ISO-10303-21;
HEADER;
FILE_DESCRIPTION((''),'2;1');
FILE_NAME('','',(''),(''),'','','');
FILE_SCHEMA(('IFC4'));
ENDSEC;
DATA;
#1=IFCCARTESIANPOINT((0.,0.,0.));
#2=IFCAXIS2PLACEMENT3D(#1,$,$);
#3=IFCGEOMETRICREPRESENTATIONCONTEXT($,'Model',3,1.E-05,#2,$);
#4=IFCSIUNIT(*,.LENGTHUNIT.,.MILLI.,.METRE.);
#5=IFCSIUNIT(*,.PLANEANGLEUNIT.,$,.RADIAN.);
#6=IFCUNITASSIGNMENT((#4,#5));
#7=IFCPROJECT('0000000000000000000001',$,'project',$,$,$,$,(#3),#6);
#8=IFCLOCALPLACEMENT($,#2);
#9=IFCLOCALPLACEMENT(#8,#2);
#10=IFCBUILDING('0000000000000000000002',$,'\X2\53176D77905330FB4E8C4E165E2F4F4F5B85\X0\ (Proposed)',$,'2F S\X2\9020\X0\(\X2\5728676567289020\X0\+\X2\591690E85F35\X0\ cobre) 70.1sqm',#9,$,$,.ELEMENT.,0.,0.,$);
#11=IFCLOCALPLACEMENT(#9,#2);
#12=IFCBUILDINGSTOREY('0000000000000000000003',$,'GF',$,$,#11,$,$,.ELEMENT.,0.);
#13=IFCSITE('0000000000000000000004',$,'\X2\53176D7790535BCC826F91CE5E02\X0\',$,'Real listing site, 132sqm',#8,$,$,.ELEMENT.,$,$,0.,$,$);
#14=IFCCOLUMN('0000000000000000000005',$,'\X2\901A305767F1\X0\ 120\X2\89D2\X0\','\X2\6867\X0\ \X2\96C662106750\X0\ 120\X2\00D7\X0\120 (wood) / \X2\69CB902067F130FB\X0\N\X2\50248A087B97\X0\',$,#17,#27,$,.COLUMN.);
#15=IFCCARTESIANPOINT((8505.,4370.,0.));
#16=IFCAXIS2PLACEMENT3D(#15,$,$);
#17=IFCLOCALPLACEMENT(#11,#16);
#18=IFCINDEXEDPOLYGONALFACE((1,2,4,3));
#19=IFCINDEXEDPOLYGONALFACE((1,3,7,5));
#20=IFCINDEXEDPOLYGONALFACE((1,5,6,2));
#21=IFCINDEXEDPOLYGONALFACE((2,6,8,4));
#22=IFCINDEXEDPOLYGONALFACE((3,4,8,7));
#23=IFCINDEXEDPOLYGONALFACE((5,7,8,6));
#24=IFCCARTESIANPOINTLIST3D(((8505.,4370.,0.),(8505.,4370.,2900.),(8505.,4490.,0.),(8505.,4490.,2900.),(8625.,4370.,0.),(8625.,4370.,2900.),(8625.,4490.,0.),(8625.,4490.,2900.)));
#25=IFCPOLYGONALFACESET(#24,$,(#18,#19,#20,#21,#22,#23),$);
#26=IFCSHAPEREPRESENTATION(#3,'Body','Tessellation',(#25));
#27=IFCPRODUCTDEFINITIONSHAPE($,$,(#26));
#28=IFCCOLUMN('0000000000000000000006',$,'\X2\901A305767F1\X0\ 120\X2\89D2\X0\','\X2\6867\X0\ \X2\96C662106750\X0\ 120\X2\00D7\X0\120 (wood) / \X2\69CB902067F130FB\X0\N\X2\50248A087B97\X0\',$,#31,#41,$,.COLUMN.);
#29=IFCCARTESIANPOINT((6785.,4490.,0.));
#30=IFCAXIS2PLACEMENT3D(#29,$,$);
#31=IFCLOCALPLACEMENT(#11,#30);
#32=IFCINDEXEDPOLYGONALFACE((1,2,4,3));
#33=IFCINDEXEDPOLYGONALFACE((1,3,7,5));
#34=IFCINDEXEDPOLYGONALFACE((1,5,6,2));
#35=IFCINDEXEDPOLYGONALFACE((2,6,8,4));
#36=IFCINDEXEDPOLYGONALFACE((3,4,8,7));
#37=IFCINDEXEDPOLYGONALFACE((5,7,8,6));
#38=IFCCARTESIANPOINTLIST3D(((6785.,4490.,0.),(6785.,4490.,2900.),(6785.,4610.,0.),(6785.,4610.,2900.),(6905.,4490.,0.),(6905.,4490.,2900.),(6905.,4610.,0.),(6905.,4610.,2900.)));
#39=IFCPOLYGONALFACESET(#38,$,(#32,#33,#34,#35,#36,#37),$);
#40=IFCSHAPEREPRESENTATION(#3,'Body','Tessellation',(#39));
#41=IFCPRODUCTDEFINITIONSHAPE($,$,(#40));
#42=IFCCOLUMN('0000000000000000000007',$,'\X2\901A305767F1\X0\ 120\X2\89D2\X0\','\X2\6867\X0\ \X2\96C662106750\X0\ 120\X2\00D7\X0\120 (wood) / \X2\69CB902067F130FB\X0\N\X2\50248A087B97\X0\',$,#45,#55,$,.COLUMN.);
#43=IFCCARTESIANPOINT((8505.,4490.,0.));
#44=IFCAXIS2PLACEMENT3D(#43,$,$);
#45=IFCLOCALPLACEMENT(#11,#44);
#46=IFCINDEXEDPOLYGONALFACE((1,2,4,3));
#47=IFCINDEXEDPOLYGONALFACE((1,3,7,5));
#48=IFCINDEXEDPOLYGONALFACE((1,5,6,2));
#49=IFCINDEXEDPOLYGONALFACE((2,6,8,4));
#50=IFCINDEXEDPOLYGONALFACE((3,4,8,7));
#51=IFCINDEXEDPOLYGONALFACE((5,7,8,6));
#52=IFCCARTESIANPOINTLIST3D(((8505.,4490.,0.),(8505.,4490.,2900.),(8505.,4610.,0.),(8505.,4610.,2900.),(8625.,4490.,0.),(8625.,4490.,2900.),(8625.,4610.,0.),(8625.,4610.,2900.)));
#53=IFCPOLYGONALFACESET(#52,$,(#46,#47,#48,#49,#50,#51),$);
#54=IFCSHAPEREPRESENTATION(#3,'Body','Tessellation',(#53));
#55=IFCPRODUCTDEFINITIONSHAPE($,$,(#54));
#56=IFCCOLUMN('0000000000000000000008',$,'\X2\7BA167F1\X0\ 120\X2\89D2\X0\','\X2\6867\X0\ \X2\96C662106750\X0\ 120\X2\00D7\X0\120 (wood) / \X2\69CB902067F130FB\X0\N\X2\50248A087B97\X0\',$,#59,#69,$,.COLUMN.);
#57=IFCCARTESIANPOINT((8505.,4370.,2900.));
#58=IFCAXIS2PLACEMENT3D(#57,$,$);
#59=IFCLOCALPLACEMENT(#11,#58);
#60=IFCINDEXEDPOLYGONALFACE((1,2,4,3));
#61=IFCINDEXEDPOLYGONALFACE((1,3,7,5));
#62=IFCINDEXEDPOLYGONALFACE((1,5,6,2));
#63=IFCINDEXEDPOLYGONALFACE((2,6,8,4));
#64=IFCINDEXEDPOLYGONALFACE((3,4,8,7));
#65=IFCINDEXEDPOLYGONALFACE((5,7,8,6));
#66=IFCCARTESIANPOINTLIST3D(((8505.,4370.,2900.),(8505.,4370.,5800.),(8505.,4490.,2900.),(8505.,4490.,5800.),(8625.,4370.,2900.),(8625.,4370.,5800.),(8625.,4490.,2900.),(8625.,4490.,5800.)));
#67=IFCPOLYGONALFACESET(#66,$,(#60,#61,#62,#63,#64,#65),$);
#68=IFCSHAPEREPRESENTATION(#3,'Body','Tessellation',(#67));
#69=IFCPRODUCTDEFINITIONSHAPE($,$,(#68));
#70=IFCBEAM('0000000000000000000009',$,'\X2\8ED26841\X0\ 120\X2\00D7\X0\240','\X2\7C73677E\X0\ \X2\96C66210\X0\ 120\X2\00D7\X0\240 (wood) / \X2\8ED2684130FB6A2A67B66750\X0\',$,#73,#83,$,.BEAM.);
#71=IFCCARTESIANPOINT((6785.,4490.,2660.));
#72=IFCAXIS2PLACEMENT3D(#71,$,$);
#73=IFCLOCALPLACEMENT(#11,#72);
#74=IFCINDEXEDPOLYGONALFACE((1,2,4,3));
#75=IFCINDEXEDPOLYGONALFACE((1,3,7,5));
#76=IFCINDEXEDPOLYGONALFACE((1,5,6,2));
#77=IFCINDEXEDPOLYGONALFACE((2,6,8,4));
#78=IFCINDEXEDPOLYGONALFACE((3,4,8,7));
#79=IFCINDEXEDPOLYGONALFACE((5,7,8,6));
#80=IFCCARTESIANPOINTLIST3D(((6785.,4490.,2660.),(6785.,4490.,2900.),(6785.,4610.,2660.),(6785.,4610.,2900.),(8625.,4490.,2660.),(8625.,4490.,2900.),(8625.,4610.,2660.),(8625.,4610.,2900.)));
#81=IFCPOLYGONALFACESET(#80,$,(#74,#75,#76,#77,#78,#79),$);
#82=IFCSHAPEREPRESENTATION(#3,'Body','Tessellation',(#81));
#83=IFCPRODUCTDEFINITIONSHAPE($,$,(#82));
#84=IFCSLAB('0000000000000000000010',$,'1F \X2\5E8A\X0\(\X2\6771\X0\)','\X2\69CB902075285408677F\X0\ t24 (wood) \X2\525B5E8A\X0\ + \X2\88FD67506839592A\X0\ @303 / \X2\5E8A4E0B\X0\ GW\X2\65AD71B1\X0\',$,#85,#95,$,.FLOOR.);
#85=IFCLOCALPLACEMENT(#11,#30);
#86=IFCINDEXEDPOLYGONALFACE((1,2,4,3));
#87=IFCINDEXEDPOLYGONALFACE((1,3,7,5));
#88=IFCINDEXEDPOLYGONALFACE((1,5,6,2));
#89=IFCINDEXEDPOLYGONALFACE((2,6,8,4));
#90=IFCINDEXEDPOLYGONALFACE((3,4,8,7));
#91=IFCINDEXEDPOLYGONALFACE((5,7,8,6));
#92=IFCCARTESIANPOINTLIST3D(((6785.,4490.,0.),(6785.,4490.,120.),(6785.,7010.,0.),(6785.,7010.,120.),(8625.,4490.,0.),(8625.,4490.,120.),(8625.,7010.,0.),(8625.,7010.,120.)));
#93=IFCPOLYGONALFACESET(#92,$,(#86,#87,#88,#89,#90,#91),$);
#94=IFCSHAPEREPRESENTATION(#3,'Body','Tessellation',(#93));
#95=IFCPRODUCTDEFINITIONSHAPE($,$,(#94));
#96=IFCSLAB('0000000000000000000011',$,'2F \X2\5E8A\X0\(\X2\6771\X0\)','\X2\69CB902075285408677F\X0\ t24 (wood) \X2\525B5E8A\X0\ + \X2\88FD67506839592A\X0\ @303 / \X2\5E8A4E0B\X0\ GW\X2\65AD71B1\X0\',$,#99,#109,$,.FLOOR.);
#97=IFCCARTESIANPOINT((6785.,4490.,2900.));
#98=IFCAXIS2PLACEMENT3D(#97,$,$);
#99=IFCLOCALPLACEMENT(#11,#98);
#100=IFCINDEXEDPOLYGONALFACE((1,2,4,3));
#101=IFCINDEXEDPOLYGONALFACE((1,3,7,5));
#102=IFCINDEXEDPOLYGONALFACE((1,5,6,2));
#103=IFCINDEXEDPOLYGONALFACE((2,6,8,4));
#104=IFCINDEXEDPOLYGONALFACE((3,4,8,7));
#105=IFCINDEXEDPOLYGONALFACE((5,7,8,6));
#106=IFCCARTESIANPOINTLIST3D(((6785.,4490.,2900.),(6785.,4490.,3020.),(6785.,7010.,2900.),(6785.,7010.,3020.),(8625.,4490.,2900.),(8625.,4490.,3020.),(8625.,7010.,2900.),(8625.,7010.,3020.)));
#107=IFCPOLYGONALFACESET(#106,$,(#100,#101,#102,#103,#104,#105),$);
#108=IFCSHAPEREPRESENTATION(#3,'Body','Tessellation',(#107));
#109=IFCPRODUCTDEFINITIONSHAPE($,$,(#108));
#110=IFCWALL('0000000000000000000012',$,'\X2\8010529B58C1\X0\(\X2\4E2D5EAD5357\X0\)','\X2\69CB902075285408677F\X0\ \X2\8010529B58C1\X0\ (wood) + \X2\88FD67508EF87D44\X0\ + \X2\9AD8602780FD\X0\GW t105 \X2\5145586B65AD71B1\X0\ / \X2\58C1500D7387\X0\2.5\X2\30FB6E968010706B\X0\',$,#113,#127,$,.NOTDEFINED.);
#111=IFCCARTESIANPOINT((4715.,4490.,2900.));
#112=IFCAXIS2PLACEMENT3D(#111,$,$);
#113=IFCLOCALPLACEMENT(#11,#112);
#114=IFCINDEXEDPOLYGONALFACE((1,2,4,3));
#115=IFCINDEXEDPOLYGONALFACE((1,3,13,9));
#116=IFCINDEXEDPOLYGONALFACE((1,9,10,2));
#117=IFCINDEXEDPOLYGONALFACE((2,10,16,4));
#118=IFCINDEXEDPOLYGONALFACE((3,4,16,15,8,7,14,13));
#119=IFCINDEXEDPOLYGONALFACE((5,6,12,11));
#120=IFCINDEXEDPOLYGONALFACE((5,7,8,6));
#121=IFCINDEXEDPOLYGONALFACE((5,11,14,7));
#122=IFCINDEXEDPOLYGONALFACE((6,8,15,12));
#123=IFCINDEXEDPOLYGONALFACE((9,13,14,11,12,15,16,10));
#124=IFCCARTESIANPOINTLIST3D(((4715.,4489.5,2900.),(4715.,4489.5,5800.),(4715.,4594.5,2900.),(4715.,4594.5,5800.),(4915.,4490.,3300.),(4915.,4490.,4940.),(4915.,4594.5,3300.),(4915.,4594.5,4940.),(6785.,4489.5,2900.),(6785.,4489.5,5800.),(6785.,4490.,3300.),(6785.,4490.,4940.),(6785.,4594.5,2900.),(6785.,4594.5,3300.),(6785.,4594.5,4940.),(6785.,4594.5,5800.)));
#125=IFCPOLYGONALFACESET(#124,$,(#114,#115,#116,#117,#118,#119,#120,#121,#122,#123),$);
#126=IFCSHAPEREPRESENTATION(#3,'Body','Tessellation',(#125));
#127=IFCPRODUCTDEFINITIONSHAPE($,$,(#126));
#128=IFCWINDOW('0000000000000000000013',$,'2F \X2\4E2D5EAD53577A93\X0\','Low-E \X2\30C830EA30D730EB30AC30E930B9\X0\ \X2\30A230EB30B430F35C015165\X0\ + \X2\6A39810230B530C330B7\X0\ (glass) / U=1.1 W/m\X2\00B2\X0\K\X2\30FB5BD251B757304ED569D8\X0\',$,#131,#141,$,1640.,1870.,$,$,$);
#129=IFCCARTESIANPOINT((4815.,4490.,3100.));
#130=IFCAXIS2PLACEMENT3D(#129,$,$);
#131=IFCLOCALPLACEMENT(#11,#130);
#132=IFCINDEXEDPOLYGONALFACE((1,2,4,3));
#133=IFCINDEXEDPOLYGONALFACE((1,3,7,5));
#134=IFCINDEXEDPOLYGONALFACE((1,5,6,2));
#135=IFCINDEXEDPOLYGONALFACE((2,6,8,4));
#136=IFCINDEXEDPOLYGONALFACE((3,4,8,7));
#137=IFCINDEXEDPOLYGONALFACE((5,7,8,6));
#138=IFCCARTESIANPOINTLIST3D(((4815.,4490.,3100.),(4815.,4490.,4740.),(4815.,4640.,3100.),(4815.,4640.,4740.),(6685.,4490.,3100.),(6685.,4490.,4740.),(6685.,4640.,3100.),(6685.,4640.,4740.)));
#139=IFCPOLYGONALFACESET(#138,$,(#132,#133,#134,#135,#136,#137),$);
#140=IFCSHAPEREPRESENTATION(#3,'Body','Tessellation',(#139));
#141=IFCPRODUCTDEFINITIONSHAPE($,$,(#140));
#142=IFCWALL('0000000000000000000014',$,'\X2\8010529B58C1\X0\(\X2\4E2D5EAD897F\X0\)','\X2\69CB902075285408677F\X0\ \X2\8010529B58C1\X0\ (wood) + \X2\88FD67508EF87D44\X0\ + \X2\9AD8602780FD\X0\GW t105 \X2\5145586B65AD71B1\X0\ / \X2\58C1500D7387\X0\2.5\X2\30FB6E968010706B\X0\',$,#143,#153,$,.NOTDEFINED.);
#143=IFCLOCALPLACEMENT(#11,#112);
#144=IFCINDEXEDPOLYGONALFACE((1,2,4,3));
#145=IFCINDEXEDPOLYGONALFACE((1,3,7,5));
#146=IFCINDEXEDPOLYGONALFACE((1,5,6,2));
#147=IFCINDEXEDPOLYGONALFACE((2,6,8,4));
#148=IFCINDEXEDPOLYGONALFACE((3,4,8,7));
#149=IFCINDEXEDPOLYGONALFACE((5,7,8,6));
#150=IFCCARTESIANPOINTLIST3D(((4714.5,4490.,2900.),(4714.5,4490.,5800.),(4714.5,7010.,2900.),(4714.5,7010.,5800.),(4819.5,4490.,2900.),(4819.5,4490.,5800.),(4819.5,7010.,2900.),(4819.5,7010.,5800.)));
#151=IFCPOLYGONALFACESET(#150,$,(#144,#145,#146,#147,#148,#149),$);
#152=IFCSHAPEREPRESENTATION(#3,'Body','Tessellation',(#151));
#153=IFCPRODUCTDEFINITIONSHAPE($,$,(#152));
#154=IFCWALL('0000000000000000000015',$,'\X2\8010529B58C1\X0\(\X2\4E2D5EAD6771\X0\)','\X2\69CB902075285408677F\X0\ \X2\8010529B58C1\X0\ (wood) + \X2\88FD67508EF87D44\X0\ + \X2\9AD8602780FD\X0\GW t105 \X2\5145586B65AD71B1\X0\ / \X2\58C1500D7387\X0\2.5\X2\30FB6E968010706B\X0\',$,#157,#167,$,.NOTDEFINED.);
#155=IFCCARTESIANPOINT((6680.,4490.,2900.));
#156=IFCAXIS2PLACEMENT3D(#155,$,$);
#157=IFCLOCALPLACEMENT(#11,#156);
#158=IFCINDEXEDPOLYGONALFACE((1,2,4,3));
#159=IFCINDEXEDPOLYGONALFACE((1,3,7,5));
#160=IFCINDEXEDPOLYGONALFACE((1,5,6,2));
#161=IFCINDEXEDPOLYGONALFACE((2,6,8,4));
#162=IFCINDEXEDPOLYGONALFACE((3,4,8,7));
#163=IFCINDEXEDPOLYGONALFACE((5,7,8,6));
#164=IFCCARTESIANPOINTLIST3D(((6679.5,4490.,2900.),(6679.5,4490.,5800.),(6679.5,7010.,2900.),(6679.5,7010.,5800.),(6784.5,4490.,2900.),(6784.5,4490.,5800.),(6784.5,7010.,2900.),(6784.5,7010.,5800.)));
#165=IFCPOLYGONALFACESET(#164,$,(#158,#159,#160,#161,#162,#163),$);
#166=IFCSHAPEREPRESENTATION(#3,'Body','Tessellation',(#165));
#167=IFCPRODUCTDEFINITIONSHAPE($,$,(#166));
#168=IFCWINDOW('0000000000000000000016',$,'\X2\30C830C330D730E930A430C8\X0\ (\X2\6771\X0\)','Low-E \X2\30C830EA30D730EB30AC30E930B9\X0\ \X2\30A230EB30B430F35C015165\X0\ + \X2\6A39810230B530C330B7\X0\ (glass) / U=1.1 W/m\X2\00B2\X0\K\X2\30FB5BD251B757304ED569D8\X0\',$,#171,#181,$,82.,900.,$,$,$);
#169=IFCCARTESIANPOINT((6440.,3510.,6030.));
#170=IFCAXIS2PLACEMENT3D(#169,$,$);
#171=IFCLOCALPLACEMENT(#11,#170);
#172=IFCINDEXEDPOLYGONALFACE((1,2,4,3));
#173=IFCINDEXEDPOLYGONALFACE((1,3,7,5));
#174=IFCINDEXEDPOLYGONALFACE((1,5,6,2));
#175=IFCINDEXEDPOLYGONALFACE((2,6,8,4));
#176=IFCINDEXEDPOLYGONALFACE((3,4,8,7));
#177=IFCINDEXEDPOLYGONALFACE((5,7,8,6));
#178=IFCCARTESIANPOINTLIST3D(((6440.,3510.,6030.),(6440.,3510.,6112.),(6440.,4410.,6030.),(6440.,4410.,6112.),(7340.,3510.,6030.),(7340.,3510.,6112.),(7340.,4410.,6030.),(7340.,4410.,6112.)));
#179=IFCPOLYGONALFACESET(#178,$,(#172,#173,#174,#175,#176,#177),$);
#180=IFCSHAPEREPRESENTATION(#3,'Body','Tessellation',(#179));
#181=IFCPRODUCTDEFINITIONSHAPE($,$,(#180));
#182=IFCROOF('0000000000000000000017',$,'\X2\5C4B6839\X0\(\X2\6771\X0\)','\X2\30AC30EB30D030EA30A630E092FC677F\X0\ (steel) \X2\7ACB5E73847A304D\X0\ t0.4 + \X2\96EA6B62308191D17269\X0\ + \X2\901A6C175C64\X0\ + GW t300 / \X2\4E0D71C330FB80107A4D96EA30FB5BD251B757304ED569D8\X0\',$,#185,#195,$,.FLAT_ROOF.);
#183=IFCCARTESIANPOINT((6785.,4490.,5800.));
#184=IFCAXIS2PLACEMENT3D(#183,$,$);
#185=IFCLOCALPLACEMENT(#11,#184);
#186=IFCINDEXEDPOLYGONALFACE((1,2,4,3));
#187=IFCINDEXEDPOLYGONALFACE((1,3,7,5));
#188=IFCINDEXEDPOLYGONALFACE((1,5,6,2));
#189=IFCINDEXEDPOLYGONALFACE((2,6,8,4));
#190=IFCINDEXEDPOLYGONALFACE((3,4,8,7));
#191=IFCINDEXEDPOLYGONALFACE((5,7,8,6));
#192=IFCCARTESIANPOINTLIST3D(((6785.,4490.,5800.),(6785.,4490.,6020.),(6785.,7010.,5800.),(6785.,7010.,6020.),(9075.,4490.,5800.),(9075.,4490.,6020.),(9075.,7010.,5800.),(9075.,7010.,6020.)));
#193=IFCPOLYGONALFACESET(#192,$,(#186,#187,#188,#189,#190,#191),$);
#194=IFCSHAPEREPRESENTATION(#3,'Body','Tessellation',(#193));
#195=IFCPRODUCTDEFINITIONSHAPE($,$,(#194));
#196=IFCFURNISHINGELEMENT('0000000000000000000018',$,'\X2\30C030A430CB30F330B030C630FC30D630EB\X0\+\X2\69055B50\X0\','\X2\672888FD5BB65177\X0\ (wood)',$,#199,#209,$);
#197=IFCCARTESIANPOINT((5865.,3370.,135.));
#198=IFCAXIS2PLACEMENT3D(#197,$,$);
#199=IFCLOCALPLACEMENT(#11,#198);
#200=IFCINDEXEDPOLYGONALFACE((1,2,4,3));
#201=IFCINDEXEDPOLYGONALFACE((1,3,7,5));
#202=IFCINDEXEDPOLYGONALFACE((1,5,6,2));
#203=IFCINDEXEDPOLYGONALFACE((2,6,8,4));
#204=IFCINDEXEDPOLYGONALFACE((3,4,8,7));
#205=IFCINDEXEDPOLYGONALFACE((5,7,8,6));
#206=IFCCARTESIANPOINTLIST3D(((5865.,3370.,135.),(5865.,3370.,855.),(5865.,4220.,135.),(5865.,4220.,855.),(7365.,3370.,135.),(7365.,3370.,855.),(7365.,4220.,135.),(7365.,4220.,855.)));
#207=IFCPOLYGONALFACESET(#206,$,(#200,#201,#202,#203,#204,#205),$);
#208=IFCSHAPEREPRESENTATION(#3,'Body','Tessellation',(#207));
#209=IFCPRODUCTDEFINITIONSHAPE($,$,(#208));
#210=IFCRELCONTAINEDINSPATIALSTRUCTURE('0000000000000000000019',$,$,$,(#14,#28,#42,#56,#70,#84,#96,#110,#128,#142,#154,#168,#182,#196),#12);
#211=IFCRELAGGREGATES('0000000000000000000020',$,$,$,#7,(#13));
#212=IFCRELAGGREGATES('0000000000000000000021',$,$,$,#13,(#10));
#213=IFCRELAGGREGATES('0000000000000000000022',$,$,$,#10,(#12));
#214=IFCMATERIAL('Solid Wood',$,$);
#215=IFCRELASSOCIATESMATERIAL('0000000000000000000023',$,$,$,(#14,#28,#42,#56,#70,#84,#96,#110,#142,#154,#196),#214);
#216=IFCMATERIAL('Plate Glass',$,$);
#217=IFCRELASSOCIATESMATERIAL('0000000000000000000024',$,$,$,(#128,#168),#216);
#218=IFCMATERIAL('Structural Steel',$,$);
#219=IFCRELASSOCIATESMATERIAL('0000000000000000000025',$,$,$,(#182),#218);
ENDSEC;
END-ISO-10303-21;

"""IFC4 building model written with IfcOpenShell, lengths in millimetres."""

from ifc_helpers import new_model, si_unit, frame, frame_2d, origin, place, context, project, spatial, rectangle, extrude, material, element, fill, save


model = new_model("IFC4")

# Units and contexts
model_context = context("Model", 3, precision=1e-05, world=origin())
ifc_project = project(units=[si_unit("LENGTHUNIT", "METRE", prefix="MILLI"), si_unit("PLANEANGLEUNIT", "RADIAN")], contexts=[model_context])

# Site, building, storey
site_placement = place(None, origin())
site = spatial("IfcSite", under=ifc_project, at=site_placement, Name="北海道富良野市", ObjectType="Real listing site, 132sqm", CompositionType="ELEMENT", RefElevation=0.0)
building_placement = place(site_placement, origin())
building = spatial("IfcBuilding", under=site, at=building_placement, Name="北海道・二世帯住宅 (Proposed)", ObjectType="2F S造(在来木造+外部張 cobre) 70.1sqm", CompositionType="ELEMENT", ElevationOfRefHeight=0.0, ElevationOfTerrain=0.0)
storey_placement = place(building_placement, origin())
storey = spatial("IfcBuildingStorey", under=building, at=storey_placement, Name="GF", CompositionType="ELEMENT", Elevation=0.0)

# Columns
ifc_material_1 = material(Name="Solid Wood")
column_1_placement = place(storey_placement, frame((8505.0, 4370.0, 0.0)))
element("IfcColumn", 1, at=column_1_placement, inside=storey, material=ifc_material_1, Name="通し柱 120角", Description="桧 集成材 120×120 (wood) / 構造柱・N値計算", PredefinedType="COLUMN", context=model_context, shape_type="SweptSolid", body=[
    extrude(rectangle(XDim=120.0, YDim=120.0, at=frame_2d((60.0, 60.0))), frame((8505.0, 4370.0, 0.0)), (0.0, 0.0, 1.0), 2900.0),
])
column_2_placement = place(storey_placement, frame((6785.0, 4490.0, 0.0)))
element("IfcColumn", 2, at=column_2_placement, inside=storey, material=ifc_material_1, Name="通し柱 120角", Description="桧 集成材 120×120 (wood) / 構造柱・N値計算", PredefinedType="COLUMN", context=model_context, shape_type="SweptSolid", body=[
    extrude(rectangle(XDim=120.0, YDim=120.0, at=frame_2d((60.0, 60.0))), frame((6785.0, 4490.0, 0.0)), (0.0, 0.0, 1.0), 2900.0),
])
column_3_placement = place(storey_placement, frame((8505.0, 4490.0, 0.0)))
element("IfcColumn", 3, at=column_3_placement, inside=storey, material=ifc_material_1, Name="通し柱 120角", Description="桧 集成材 120×120 (wood) / 構造柱・N値計算", PredefinedType="COLUMN", context=model_context, shape_type="SweptSolid", body=[
    extrude(rectangle(XDim=120.0, YDim=120.0, at=frame_2d((60.0, 60.0))), frame((8505.0, 4490.0, 0.0)), (0.0, 0.0, 1.0), 2900.0),
])
column_4_placement = place(storey_placement, frame((8505.0, 4370.0, 2900.0)))
element("IfcColumn", 4, at=column_4_placement, inside=storey, material=ifc_material_1, Name="管柱 120角", Description="桧 集成材 120×120 (wood) / 構造柱・N値計算", PredefinedType="COLUMN", context=model_context, shape_type="SweptSolid", body=[
    extrude(rectangle(XDim=120.0, YDim=120.0, at=frame_2d((60.0, 60.0))), frame((8505.0, 4370.0, 2900.0)), (0.0, 0.0, 1.0), 2900.0),
])

# Beam
beam_1_placement = place(storey_placement, frame((6785.0, 4490.0, 2660.0)))
element("IfcBeam", 5, at=beam_1_placement, inside=storey, material=ifc_material_1, Name="軒桁 120×240", Description="米松 集成 120×240 (wood) / 軒桁・横架材", PredefinedType="BEAM", context=model_context, shape_type="SweptSolid", body=[
    extrude(rectangle(XDim=1840.0, YDim=120.0, at=frame_2d((920.0, 60.0))), frame((6785.0, 4490.0, 2660.0)), (0.0, 0.0, 1.0), 240.0),
])

# Slabs
slab_1_placement = place(storey_placement, frame((6785.0, 4490.0, 0.0)))
element("IfcSlab", 6, at=slab_1_placement, inside=storey, material=ifc_material_1, Name="1F 床(東)", Description="構造用合板 t24 (wood) 剛床 + 製材根太 @303 / 床下 GW断熱", PredefinedType="FLOOR", context=model_context, shape_type="SweptSolid", body=[
    extrude(rectangle(XDim=1840.0, YDim=2520.0, at=frame_2d((920.0, 1260.0))), frame((6785.0, 4490.0, 0.0)), (0.0, 0.0, 1.0), 120.0),
])
slab_2_placement = place(storey_placement, frame((6785.0, 4490.0, 2900.0)))
element("IfcSlab", 7, at=slab_2_placement, inside=storey, material=ifc_material_1, Name="2F 床(東)", Description="構造用合板 t24 (wood) 剛床 + 製材根太 @303 / 床下 GW断熱", PredefinedType="FLOOR", context=model_context, shape_type="SweptSolid", body=[
    extrude(rectangle(XDim=1840.0, YDim=2520.0, at=frame_2d((920.0, 1260.0))), frame((6785.0, 4490.0, 2900.0)), (0.0, 0.0, 1.0), 120.0),
])

# Wall, opening, window
wall_1_placement = place(storey_placement, frame((4715.0, 4490.0, 2900.0)))
wall_1 = element("IfcWall", 8, at=wall_1_placement, inside=storey, material=ifc_material_1, Name="耐力壁(中庭南)", Description="構造用合板 耐力壁 (wood) + 製材軸組 + 高性能GW t105 充填断熱 / 壁倍率2.5・準耐火", PredefinedType="NOTDEFINED", context=model_context, shape_type="SweptSolid", body=[
    extrude(rectangle(XDim=2070.0, YDim=105.0, at=frame_2d((1035.0, 52.0))), frame((4715.0, 4490.0, 2900.0)), (0.0, 0.0, 1.0), 2900.0),
])
opening_placement = place(storey_placement, frame((4815.0, 4490.0, 3100.0)))
opening = element("IfcOpeningElement", 9, at=opening_placement, cuts=wall_1, PredefinedType="NOTDEFINED", context=model_context, shape_type="SweptSolid", body=[
    extrude(rectangle(XDim=1870.0, YDim=150.0, at=frame_2d((935.0, 75.0))), frame((4815.0, 4490.0, 3100.0)), (0.0, 0.0, 1.0), 1640.0),
])
ifc_material_2 = material(Name="Plate Glass")
window_1_placement = place(storey_placement, frame((4815.0, 4490.0, 3100.0)))
window_1 = element("IfcWindow", 10, at=window_1_placement, inside=storey, material=ifc_material_2, Name="2F 中庭南窓", Description="Low-E トリプルガラス アルゴン封入 + 樹脂サッシ (glass) / U=1.1 W/m²K・寒冷地仕様", OverallHeight=1640.0, OverallWidth=1870.0, context=model_context, shape_type="SweptSolid", body=[
    extrude(rectangle(XDim=1870.0, YDim=150.0, at=frame_2d((935.0, 75.0))), frame((4815.0, 4490.0, 3100.0)), (0.0, 0.0, 1.0), 1640.0),
])
fill(opening, window_1)

# Walls
wall_2_placement = place(storey_placement, frame((4715.0, 4490.0, 2900.0)))
element("IfcWall", 11, at=wall_2_placement, inside=storey, material=ifc_material_1, Name="耐力壁(中庭西)", Description="構造用合板 耐力壁 (wood) + 製材軸組 + 高性能GW t105 充填断熱 / 壁倍率2.5・準耐火", PredefinedType="NOTDEFINED", context=model_context, shape_type="SweptSolid", body=[
    extrude(rectangle(XDim=105.0, YDim=2520.0, at=frame_2d((52.0, 1260.0))), frame((4715.0, 4490.0, 2900.0)), (0.0, 0.0, 1.0), 2900.0),
])
wall_3_placement = place(storey_placement, frame((6680.0, 4490.0, 2900.0)))
element("IfcWall", 12, at=wall_3_placement, inside=storey, material=ifc_material_1, Name="耐力壁(中庭東)", Description="構造用合板 耐力壁 (wood) + 製材軸組 + 高性能GW t105 充填断熱 / 壁倍率2.5・準耐火", PredefinedType="NOTDEFINED", context=model_context, shape_type="SweptSolid", body=[
    extrude(rectangle(XDim=105.0, YDim=2520.0, at=frame_2d((52.0, 1260.0))), frame((6680.0, 4490.0, 2900.0)), (0.0, 0.0, 1.0), 2900.0),
])

# Window
window_2_placement = place(storey_placement, frame((6440.0, 3510.0, 6030.0)))
element("IfcWindow", 13, at=window_2_placement, inside=storey, material=ifc_material_2, Name="トップライト (東)", Description="Low-E トリプルガラス アルゴン封入 + 樹脂サッシ (glass) / U=1.1 W/m²K・寒冷地仕様", OverallHeight=82.0, OverallWidth=900.0, context=model_context, shape_type="SweptSolid", body=[
    extrude(rectangle(XDim=900.0, YDim=900.0, at=frame_2d((450.0, 450.0))), frame((6440.0, 3510.0, 6030.0)), (0.0, 0.0, 1.0), 82.0),
])

# Roof
ifc_material_3 = material(Name="Structural Steel")
for number, where, name in (
    (14, (6785.0, 4490.0, 5800.0), "屋根(東)"),
):
    element("IfcRoof", number, at=place(storey_placement, frame(where)), inside=storey, material=ifc_material_3, Name=name, Description="ガルバリウム鋼板 (steel) 立平葺き t0.4 + 雪止め金物 + 通気層 + GW t300 / 不燃・耐積雪・寒冷地仕様", PredefinedType="FLAT_ROOF", context=model_context, shape_type="SweptSolid", body=[
        extrude(rectangle(XDim=2290.0, YDim=2520.0, at=frame_2d((1145.0, 1260.0))), frame((6785.0, 4490.0, 5800.0)), (0.0, 0.0, 1.0), 220.0),
    ])

# Furnishing element
furnishing_1_placement = place(storey_placement, frame((5865.0, 3370.0, 135.0)))
element("IfcFurnishingElement", 15, at=furnishing_1_placement, inside=storey, material=ifc_material_1, Name="ダイニングテーブル+椅子", Description="木製家具 (wood)", context=model_context, shape_type="SweptSolid", body=[
    extrude(rectangle(XDim=1500.0, YDim=850.0, at=frame_2d((750.0, 425.0))), frame((5865.0, 3370.0, 135.0)), (0.0, 0.0, 1.0), 720.0),
])

save(model, "model.ifc")
